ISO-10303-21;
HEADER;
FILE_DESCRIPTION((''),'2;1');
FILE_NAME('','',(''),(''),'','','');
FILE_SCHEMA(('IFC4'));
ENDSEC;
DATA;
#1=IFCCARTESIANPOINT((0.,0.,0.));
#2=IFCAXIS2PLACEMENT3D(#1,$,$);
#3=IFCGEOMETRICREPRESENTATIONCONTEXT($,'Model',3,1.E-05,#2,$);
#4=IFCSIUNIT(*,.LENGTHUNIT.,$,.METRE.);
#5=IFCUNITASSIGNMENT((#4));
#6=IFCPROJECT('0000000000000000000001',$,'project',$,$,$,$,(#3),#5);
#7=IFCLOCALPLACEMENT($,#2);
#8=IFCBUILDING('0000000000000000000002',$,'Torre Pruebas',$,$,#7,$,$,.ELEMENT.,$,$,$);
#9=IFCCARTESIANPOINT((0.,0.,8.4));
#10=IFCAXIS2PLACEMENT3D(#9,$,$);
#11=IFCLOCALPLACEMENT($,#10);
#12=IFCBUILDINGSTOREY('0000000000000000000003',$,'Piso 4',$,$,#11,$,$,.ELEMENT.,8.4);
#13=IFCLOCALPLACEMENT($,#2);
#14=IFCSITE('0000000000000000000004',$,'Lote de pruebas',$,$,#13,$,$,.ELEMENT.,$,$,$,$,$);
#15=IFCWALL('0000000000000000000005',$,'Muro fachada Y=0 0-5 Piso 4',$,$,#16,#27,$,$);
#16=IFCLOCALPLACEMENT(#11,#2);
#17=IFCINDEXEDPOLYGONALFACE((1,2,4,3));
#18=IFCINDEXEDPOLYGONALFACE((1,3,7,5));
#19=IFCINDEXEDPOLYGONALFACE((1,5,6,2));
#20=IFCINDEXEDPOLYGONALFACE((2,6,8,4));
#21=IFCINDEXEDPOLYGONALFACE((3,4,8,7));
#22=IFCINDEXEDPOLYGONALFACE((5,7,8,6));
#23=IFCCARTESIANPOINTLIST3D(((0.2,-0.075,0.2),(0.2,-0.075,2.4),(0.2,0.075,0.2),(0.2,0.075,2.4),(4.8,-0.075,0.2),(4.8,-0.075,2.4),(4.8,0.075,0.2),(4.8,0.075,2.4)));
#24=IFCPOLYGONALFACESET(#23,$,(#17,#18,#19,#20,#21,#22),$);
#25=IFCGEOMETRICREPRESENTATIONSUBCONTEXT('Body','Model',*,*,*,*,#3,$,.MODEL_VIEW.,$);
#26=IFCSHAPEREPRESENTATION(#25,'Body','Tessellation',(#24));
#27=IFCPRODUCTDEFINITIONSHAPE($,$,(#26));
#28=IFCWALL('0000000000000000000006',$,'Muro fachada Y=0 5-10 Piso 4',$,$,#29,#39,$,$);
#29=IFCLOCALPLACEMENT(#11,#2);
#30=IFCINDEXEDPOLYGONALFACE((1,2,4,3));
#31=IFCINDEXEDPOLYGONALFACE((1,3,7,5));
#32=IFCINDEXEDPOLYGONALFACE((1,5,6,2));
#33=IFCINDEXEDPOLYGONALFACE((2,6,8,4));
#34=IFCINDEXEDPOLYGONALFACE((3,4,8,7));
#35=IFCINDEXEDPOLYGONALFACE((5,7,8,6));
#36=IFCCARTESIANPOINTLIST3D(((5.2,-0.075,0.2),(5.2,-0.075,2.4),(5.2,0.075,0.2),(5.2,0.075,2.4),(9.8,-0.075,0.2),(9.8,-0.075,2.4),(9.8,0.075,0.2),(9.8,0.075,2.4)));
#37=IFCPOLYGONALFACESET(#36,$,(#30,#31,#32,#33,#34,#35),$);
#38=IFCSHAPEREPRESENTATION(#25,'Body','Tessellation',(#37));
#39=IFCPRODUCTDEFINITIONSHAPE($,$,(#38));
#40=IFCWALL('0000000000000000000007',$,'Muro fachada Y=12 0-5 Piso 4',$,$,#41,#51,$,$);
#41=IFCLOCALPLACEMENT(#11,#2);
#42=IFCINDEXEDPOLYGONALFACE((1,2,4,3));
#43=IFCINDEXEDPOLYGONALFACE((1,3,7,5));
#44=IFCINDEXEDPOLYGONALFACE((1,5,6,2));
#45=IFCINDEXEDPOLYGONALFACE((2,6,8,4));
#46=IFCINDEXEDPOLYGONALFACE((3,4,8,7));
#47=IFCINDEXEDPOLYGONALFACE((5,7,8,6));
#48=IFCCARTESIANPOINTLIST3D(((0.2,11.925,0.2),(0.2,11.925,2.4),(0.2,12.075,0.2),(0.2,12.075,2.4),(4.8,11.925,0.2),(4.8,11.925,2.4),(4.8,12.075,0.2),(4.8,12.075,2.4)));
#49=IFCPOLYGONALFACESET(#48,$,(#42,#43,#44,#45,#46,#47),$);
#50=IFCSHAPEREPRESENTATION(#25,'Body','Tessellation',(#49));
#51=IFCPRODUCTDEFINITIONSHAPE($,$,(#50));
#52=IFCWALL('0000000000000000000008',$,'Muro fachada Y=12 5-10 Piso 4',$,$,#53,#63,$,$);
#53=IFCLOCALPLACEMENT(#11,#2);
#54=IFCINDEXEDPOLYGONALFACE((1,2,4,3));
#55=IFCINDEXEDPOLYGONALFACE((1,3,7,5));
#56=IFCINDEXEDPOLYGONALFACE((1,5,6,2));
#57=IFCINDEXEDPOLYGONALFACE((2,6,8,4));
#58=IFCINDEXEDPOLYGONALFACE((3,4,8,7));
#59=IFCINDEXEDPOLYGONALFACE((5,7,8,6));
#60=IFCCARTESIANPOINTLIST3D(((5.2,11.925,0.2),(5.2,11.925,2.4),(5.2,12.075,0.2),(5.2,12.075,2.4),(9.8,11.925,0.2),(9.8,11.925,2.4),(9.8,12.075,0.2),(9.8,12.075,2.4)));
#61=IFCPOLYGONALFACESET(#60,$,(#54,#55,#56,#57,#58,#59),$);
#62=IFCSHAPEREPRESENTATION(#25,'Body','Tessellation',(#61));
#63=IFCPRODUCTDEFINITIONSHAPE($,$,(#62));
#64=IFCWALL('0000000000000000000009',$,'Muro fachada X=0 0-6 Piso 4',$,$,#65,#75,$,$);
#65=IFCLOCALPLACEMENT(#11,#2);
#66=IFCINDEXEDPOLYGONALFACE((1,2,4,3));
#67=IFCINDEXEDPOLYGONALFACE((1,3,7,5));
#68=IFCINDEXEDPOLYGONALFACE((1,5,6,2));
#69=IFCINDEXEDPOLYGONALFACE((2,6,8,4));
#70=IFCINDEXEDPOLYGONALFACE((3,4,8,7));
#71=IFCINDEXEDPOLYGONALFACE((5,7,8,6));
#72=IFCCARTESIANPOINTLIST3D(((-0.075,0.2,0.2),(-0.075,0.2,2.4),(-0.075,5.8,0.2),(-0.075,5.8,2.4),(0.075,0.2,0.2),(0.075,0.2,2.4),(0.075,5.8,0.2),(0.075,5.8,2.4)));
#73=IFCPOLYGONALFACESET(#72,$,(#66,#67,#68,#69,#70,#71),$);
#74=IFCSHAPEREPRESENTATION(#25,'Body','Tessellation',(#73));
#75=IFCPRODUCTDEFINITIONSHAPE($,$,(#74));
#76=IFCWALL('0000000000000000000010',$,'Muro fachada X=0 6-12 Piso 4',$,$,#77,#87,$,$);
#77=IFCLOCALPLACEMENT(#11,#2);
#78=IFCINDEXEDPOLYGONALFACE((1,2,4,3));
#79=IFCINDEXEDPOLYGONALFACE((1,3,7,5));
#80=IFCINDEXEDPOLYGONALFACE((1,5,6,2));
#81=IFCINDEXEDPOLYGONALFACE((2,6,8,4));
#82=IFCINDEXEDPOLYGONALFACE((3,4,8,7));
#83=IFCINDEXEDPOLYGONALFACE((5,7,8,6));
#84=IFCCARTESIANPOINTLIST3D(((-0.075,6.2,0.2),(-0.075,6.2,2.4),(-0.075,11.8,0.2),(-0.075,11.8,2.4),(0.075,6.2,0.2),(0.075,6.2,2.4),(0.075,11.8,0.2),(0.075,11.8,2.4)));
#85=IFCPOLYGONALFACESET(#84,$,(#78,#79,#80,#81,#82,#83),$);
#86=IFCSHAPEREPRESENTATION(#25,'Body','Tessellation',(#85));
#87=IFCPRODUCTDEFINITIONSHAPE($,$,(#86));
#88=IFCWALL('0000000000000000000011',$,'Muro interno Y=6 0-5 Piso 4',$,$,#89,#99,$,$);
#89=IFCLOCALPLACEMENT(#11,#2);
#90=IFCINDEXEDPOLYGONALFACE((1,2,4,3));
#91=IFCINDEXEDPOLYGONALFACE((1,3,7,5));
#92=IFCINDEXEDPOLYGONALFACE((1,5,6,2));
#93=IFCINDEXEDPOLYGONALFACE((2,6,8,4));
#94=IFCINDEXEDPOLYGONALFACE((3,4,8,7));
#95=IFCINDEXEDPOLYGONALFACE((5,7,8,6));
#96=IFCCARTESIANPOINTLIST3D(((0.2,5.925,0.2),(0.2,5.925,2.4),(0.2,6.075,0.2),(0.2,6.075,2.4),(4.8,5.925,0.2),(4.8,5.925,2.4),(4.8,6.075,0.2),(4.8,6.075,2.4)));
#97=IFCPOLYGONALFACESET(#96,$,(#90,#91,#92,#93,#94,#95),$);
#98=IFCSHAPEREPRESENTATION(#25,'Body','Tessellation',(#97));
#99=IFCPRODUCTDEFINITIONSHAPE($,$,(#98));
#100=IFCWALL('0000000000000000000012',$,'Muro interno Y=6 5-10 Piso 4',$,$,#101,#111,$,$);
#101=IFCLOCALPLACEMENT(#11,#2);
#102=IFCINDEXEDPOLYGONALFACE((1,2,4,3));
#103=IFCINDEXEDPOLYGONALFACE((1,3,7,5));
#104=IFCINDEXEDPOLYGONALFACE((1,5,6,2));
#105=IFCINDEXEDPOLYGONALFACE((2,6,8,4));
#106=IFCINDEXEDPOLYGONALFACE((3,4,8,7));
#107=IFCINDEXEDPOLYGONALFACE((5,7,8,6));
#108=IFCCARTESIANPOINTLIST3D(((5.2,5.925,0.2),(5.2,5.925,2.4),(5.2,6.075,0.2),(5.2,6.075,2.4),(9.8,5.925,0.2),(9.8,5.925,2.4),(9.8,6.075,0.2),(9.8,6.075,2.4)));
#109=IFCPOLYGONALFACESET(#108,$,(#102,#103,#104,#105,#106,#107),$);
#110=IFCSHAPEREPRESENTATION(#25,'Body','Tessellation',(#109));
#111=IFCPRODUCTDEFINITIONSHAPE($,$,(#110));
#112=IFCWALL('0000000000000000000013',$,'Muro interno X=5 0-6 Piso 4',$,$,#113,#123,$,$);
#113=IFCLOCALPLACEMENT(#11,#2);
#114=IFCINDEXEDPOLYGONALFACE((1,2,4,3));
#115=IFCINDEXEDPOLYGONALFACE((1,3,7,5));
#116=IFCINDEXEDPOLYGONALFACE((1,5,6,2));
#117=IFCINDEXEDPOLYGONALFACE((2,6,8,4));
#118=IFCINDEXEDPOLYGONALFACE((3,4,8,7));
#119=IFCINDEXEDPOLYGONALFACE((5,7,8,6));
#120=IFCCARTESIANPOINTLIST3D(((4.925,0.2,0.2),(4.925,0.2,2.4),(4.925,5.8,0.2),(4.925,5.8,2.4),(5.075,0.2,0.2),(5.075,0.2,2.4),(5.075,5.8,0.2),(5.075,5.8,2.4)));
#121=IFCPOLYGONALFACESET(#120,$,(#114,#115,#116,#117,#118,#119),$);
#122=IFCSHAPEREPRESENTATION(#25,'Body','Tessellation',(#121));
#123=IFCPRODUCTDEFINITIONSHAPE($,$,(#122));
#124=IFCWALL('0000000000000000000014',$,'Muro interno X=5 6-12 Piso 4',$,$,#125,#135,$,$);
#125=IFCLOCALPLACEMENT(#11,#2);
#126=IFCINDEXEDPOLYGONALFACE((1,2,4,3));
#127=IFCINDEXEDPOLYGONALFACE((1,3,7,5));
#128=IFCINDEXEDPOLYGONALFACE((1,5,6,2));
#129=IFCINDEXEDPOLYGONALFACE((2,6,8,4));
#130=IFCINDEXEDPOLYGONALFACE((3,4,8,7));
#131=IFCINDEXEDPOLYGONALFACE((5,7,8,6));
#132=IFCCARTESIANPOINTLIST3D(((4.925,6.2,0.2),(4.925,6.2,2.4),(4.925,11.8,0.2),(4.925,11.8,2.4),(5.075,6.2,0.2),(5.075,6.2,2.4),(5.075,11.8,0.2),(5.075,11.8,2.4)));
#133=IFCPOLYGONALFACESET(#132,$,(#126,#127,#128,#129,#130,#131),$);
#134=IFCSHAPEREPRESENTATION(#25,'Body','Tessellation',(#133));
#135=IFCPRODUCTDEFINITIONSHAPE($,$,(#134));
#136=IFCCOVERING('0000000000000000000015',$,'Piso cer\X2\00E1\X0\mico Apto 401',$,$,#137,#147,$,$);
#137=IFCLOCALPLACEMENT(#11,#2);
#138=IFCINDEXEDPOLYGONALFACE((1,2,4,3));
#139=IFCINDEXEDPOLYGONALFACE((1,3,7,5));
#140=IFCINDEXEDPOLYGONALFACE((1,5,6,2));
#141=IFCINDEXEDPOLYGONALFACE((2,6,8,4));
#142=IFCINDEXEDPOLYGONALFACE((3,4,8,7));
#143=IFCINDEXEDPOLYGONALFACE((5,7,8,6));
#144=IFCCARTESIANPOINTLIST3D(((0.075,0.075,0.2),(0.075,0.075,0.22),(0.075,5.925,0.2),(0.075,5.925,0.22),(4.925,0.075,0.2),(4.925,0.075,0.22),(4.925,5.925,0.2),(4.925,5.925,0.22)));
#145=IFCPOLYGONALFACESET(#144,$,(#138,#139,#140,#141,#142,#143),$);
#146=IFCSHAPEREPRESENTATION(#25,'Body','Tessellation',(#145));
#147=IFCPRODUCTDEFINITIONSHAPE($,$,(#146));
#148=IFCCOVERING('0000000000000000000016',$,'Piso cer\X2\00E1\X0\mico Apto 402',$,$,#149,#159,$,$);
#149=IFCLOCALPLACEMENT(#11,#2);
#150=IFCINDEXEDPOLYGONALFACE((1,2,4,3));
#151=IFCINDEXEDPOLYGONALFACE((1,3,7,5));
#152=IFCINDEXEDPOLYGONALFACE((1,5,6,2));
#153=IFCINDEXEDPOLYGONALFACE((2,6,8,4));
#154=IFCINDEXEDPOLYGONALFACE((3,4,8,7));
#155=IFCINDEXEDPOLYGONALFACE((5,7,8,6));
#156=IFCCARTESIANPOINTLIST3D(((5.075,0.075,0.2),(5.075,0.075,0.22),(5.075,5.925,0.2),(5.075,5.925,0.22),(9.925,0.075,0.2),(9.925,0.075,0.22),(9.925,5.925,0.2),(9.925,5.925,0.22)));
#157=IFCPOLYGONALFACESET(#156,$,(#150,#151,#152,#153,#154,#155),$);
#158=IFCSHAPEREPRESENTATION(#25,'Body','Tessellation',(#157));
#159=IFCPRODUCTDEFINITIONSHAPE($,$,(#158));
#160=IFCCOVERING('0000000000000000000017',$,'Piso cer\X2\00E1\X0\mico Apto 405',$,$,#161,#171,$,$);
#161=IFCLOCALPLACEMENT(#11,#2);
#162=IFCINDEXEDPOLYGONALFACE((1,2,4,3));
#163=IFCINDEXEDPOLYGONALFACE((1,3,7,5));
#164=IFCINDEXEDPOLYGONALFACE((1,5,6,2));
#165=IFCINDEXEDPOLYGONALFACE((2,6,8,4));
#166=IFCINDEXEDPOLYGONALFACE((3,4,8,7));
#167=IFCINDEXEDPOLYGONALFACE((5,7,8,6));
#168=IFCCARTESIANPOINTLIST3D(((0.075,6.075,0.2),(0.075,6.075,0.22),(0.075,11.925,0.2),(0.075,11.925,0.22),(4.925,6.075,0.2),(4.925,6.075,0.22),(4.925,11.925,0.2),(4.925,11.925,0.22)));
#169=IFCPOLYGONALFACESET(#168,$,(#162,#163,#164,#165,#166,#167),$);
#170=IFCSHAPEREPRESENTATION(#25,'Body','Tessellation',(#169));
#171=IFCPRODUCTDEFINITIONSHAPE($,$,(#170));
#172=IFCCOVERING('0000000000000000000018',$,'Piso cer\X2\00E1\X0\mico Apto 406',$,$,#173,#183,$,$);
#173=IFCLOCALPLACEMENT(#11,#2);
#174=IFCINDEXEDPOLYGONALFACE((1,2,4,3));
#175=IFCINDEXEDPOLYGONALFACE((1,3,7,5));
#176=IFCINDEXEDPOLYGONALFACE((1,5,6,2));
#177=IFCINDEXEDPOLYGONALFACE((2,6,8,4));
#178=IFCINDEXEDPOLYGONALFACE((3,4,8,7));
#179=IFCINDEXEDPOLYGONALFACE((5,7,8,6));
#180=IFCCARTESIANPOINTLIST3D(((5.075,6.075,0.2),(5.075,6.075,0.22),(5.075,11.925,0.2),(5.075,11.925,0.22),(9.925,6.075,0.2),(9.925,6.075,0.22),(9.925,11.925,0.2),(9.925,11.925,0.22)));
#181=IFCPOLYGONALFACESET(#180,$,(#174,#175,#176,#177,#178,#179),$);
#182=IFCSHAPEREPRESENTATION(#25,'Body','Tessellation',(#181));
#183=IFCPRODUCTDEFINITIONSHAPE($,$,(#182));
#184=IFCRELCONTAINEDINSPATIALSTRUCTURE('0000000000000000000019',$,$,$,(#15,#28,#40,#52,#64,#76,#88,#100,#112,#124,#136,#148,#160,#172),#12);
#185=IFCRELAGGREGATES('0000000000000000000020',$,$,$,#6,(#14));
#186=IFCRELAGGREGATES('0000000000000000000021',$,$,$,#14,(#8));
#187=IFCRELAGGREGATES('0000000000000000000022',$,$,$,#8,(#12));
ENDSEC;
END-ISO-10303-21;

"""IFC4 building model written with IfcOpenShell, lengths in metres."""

from ifc_helpers import new_model, si_unit, frame, origin, origin_2d, place, context, subcontext, project, spatial, rectangle, extrude, element, save


model = new_model("IFC4")

# Units and contexts
model_context = context("Model", 3, precision=1e-05, world=origin())
body_context = subcontext(model_context, "Body", "Model", "MODEL_VIEW")
ifc_project = project(units=[si_unit("LENGTHUNIT", "METRE")], contexts=[model_context])

# Site, building, storey
site_placement = place(None, origin())
site = spatial("IfcSite", under=ifc_project, at=site_placement, Name="Lote de pruebas", CompositionType="ELEMENT")
building_placement = place(None, origin())
building = spatial("IfcBuilding", under=site, at=building_placement, Name="Torre Pruebas", CompositionType="ELEMENT")
storey_placement = place(None, frame((0.0, 0.0, 8.4)))
storey = spatial("IfcBuildingStorey", under=building, at=storey_placement, Name="Piso 4", CompositionType="ELEMENT", Elevation=8.4)

# Walls
for number, where, name in (
    (1, (2.5, 0.0, 8.6), "Muro fachada Y=0 0-5 Piso 4"),
    (2, (7.5, 0.0, 8.6), "Muro fachada Y=0 5-10 Piso 4"),
    (3, (2.5, 12.0, 8.6), "Muro fachada Y=12 0-5 Piso 4"),
    (4, (7.5, 12.0, 8.6), "Muro fachada Y=12 5-10 Piso 4"),
):
    element("IfcWall", number, at=place(None, frame(where)), inside=storey, Name=name, context=body_context, shape_type="SweptSolid", body=[
        extrude(rectangle(XDim=4.6, YDim=0.15, at=origin_2d()), origin(), (0.0, 0.0, 1.0), 2.2),
    ])
for number, where, name in (
    (5, (0.0, 3.0, 8.6), "Muro fachada X=0 0-6 Piso 4"),
    (6, (0.0, 9.0, 8.6), "Muro fachada X=0 6-12 Piso 4"),
):
    element("IfcWall", number, at=place(None, frame(where)), inside=storey, Name=name, context=body_context, shape_type="SweptSolid", body=[
        extrude(rectangle(XDim=0.15, YDim=5.6, at=origin_2d()), origin(), (0.0, 0.0, 1.0), 2.2),
    ])
for number, where, name in (
    (7, (2.5, 6.0, 8.6), "Muro interno Y=6 0-5 Piso 4"),
    (8, (7.5, 6.0, 8.6), "Muro interno Y=6 5-10 Piso 4"),
):
    element("IfcWall", number, at=place(None, frame(where)), inside=storey, Name=name, context=body_context, shape_type="SweptSolid", body=[
        extrude(rectangle(XDim=4.6, YDim=0.15, at=origin_2d()), origin(), (0.0, 0.0, 1.0), 2.2),
    ])
for number, where, name in (
    (9, (5.0, 3.0, 8.6), "Muro interno X=5 0-6 Piso 4"),
    (10, (5.0, 9.0, 8.6), "Muro interno X=5 6-12 Piso 4"),
):
    element("IfcWall", number, at=place(None, frame(where)), inside=storey, Name=name, context=body_context, shape_type="SweptSolid", body=[
        extrude(rectangle(XDim=0.15, YDim=5.6, at=origin_2d()), origin(), (0.0, 0.0, 1.0), 2.2),
    ])

# Coverings
for number, where, name in (
    (11, (2.5, 3.0, 8.6), "Piso cerámico Apto 401"),
    (12, (7.5, 3.0, 8.6), "Piso cerámico Apto 402"),
    (13, (2.5, 9.0, 8.6), "Piso cerámico Apto 405"),
    (14, (7.5, 9.0, 8.6), "Piso cerámico Apto 406"),
):
    element("IfcCovering", number, at=place(None, frame(where)), inside=storey, Name=name, context=body_context, shape_type="SweptSolid", body=[
        extrude(rectangle(XDim=4.85, YDim=5.85, at=origin_2d()), origin(), (0.0, 0.0, 1.0), 0.02),
    ])

save(model, "model.ifc")
